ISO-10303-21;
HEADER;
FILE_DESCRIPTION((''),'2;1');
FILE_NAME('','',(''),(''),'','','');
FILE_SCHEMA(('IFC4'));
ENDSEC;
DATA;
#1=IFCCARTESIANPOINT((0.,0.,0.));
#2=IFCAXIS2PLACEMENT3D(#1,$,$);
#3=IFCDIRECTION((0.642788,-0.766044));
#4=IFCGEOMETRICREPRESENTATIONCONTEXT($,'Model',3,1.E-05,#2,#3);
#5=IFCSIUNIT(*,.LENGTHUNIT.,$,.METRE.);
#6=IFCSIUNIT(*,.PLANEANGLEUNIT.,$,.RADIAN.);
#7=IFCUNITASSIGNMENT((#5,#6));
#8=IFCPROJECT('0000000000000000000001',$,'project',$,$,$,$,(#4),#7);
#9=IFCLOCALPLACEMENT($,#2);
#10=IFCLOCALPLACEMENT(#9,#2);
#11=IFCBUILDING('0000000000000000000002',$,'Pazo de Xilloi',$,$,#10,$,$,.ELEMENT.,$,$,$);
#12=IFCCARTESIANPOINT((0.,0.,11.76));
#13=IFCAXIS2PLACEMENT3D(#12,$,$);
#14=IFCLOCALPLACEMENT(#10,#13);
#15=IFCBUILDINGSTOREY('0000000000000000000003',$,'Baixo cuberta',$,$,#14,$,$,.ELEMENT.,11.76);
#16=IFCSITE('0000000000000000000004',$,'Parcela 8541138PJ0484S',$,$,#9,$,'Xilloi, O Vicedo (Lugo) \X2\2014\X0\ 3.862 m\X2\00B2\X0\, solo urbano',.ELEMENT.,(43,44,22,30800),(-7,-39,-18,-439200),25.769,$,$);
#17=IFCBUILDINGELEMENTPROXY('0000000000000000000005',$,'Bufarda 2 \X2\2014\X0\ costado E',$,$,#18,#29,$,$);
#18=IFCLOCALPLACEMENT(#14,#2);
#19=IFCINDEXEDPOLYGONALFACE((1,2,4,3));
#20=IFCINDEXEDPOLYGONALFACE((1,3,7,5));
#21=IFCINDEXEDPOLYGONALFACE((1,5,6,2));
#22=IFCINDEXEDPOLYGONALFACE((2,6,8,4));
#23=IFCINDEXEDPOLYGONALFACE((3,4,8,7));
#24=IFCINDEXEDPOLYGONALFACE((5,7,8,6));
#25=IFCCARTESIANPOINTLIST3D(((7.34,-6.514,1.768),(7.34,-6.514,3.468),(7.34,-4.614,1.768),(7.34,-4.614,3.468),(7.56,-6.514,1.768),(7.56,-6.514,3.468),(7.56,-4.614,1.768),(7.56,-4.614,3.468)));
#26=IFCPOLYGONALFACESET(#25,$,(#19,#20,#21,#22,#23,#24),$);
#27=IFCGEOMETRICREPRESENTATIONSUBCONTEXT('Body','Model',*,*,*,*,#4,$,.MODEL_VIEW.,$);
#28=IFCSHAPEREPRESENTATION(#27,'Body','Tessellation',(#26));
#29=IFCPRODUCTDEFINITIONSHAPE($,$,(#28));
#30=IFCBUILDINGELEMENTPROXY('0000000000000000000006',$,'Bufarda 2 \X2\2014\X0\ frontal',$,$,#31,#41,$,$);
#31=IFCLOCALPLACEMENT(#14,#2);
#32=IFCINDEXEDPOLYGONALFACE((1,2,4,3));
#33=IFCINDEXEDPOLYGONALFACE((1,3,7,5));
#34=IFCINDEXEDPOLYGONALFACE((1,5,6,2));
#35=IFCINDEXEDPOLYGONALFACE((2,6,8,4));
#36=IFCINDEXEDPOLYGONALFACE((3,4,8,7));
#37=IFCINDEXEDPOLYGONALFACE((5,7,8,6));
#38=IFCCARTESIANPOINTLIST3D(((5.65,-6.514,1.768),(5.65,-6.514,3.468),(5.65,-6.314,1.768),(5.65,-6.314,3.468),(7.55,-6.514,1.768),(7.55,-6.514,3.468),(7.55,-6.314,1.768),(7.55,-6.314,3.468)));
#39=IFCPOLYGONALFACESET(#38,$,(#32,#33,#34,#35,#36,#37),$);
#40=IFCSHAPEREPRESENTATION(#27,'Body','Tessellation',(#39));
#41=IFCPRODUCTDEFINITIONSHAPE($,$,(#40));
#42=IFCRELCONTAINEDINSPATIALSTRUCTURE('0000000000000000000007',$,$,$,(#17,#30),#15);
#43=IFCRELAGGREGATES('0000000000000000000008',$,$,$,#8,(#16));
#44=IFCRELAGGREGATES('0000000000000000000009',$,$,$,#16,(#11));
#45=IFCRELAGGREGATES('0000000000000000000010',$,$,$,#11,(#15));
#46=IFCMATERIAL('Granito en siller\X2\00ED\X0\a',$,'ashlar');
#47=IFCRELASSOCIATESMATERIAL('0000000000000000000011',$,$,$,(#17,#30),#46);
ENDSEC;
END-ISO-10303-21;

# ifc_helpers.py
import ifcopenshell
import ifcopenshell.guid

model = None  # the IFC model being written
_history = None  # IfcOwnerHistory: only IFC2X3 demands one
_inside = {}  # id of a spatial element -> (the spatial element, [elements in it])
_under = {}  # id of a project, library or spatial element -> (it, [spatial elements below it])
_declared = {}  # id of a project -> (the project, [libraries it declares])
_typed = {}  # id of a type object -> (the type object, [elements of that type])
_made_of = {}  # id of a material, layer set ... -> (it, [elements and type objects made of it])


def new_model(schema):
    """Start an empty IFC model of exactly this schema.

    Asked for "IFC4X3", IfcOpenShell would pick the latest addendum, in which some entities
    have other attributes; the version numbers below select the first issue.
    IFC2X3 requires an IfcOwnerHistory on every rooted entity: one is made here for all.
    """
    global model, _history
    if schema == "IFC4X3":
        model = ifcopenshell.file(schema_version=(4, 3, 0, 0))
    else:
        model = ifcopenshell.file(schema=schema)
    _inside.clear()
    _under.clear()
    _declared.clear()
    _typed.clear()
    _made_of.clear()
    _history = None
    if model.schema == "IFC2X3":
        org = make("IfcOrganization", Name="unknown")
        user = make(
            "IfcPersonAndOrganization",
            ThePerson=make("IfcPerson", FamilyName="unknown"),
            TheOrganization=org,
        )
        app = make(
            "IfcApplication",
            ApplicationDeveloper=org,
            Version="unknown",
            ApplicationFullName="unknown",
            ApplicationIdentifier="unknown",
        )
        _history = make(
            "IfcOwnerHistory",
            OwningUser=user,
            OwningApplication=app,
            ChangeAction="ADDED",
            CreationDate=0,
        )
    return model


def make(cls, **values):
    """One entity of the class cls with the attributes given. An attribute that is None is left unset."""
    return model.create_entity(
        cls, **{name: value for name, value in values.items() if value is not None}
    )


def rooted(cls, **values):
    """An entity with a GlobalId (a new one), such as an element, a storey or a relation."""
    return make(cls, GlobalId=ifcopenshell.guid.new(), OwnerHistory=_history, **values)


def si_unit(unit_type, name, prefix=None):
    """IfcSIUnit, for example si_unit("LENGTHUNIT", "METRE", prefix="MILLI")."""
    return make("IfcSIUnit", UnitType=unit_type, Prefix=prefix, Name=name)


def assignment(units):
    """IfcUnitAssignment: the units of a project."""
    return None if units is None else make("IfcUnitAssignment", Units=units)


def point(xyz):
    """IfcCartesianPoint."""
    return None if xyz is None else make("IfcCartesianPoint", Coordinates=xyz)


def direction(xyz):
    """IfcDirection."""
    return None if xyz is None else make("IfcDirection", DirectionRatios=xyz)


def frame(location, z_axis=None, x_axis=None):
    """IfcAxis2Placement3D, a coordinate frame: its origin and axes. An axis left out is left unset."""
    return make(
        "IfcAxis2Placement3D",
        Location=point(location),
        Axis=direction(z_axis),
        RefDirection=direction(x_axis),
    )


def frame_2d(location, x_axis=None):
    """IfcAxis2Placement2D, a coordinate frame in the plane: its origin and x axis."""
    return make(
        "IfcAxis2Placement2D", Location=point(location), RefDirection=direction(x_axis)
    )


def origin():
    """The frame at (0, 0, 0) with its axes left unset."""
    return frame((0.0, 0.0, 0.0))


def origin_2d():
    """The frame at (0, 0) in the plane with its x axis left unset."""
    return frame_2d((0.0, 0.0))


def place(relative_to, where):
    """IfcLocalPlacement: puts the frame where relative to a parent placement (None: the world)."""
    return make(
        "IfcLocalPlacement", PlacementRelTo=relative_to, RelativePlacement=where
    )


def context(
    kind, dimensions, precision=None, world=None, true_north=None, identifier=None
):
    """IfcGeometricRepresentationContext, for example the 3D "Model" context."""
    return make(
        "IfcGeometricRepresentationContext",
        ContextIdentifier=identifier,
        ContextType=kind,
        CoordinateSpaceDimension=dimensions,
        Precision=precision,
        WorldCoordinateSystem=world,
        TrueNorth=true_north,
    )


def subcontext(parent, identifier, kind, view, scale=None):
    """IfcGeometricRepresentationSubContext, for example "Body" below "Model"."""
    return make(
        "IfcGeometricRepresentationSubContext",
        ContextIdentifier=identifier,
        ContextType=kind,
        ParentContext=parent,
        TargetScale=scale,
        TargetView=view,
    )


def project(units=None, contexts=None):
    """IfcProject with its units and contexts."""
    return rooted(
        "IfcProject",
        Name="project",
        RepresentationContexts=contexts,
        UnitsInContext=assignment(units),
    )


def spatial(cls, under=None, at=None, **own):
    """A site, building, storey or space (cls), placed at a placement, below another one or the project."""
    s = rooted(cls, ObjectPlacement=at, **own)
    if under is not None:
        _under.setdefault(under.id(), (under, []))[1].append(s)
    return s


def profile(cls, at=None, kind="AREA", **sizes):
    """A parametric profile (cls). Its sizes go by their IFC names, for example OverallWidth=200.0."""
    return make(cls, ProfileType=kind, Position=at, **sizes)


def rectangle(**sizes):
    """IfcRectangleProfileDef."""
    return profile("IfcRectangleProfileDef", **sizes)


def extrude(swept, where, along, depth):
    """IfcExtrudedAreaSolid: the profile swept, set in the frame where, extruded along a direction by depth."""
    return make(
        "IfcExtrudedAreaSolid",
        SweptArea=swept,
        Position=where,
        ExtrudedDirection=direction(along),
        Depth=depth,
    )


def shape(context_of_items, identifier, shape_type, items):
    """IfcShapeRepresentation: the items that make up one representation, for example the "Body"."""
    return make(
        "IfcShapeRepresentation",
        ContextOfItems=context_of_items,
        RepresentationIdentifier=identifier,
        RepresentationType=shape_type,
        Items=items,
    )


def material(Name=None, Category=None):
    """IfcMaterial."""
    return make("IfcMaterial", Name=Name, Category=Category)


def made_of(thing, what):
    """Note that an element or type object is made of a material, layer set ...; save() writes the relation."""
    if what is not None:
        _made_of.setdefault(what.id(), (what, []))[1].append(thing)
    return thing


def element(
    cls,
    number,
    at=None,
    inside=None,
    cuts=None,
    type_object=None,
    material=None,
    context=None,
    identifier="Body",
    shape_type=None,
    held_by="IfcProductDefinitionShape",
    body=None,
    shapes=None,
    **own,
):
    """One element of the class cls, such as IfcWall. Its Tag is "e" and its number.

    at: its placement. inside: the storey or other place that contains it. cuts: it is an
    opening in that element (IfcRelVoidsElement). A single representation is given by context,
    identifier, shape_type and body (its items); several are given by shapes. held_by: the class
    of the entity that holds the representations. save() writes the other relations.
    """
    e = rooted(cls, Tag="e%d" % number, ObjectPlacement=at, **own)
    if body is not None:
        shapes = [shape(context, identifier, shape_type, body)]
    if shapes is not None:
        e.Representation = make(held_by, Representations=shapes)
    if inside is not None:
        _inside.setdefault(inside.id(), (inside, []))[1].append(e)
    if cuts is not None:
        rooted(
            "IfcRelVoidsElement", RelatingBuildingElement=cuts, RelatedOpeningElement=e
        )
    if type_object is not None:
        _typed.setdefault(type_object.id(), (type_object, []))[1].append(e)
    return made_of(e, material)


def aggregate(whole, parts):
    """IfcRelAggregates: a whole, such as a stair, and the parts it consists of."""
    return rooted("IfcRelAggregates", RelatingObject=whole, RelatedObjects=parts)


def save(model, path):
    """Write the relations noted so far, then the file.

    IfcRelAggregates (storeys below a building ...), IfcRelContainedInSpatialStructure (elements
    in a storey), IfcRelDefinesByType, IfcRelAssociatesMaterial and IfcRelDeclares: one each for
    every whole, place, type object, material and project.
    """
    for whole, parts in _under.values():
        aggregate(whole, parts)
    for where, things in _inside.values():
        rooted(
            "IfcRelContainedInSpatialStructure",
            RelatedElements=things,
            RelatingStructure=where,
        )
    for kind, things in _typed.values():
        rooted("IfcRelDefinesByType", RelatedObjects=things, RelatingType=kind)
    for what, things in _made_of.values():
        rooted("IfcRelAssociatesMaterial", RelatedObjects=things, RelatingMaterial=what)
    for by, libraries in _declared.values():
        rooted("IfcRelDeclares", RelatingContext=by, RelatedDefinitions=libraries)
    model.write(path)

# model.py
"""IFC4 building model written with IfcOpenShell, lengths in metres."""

from ifc_helpers import new_model, si_unit, direction, frame, origin, origin_2d, place, context, subcontext, project, spatial, rectangle, extrude, material, element, save


model = new_model("IFC4")

# Units and contexts
model_context = context("Model", 3, precision=1e-05, world=origin(), true_north=direction((0.642788, -0.766044)))
body_context = subcontext(model_context, "Body", "Model", "MODEL_VIEW")
ifc_project = project(units=[si_unit("LENGTHUNIT", "METRE"), si_unit("PLANEANGLEUNIT", "RADIAN")], contexts=[model_context])

# Site, building, storey
site_placement = place(None, origin())
site = spatial("IfcSite", under=ifc_project, at=site_placement, Name="Parcela 8541138PJ0484S", LongName="Xilloi, O Vicedo (Lugo) — 3.862 m², solo urbano", CompositionType="ELEMENT", RefLatitude=(43, 44, 22, 30800), RefLongitude=(-7, -39, -18, -439200), RefElevation=25.769)
building_placement = place(site_placement, origin())
building = spatial("IfcBuilding", under=site, at=building_placement, Name="Pazo de Xilloi", CompositionType="ELEMENT")
storey_placement = place(building_placement, frame((0.0, 0.0, 11.76)))
storey = spatial("IfcBuildingStorey", under=building, at=storey_placement, Name="Baixo cuberta", CompositionType="ELEMENT", Elevation=11.76)

# Shared definitions
ifc_material_1 = material(Name="Granito en sillería", Category="ashlar")

# Building element proxies
for number, where, name in (
    (1, (7.45, -5.564, 2.618), "Bufarda 2 — costado E"),
):
    element("IfcBuildingElementProxy", number, at=place(storey_placement, frame(where)), inside=storey, material=ifc_material_1, Name=name, context=body_context, shape_type="SweptSolid", body=[
        extrude(rectangle(XDim=0.22, YDim=1.9, at=origin_2d()), frame((0.0, 0.0, -0.85)), (0.0, 0.0, 1.0), 1.7),
    ])
proxy_placement = place(storey_placement, frame((6.6, -6.414, 2.618)))
element("IfcBuildingElementProxy", 2, at=proxy_placement, inside=storey, material=ifc_material_1, Name="Bufarda 2 — frontal", context=body_context, shape_type="SweptSolid", body=[
    extrude(rectangle(XDim=1.9, YDim=0.2, at=origin_2d()), frame((0.0, 0.0, -0.85)), (0.0, 0.0, 1.0), 1.7),
])

save(model, "model.ifc")
